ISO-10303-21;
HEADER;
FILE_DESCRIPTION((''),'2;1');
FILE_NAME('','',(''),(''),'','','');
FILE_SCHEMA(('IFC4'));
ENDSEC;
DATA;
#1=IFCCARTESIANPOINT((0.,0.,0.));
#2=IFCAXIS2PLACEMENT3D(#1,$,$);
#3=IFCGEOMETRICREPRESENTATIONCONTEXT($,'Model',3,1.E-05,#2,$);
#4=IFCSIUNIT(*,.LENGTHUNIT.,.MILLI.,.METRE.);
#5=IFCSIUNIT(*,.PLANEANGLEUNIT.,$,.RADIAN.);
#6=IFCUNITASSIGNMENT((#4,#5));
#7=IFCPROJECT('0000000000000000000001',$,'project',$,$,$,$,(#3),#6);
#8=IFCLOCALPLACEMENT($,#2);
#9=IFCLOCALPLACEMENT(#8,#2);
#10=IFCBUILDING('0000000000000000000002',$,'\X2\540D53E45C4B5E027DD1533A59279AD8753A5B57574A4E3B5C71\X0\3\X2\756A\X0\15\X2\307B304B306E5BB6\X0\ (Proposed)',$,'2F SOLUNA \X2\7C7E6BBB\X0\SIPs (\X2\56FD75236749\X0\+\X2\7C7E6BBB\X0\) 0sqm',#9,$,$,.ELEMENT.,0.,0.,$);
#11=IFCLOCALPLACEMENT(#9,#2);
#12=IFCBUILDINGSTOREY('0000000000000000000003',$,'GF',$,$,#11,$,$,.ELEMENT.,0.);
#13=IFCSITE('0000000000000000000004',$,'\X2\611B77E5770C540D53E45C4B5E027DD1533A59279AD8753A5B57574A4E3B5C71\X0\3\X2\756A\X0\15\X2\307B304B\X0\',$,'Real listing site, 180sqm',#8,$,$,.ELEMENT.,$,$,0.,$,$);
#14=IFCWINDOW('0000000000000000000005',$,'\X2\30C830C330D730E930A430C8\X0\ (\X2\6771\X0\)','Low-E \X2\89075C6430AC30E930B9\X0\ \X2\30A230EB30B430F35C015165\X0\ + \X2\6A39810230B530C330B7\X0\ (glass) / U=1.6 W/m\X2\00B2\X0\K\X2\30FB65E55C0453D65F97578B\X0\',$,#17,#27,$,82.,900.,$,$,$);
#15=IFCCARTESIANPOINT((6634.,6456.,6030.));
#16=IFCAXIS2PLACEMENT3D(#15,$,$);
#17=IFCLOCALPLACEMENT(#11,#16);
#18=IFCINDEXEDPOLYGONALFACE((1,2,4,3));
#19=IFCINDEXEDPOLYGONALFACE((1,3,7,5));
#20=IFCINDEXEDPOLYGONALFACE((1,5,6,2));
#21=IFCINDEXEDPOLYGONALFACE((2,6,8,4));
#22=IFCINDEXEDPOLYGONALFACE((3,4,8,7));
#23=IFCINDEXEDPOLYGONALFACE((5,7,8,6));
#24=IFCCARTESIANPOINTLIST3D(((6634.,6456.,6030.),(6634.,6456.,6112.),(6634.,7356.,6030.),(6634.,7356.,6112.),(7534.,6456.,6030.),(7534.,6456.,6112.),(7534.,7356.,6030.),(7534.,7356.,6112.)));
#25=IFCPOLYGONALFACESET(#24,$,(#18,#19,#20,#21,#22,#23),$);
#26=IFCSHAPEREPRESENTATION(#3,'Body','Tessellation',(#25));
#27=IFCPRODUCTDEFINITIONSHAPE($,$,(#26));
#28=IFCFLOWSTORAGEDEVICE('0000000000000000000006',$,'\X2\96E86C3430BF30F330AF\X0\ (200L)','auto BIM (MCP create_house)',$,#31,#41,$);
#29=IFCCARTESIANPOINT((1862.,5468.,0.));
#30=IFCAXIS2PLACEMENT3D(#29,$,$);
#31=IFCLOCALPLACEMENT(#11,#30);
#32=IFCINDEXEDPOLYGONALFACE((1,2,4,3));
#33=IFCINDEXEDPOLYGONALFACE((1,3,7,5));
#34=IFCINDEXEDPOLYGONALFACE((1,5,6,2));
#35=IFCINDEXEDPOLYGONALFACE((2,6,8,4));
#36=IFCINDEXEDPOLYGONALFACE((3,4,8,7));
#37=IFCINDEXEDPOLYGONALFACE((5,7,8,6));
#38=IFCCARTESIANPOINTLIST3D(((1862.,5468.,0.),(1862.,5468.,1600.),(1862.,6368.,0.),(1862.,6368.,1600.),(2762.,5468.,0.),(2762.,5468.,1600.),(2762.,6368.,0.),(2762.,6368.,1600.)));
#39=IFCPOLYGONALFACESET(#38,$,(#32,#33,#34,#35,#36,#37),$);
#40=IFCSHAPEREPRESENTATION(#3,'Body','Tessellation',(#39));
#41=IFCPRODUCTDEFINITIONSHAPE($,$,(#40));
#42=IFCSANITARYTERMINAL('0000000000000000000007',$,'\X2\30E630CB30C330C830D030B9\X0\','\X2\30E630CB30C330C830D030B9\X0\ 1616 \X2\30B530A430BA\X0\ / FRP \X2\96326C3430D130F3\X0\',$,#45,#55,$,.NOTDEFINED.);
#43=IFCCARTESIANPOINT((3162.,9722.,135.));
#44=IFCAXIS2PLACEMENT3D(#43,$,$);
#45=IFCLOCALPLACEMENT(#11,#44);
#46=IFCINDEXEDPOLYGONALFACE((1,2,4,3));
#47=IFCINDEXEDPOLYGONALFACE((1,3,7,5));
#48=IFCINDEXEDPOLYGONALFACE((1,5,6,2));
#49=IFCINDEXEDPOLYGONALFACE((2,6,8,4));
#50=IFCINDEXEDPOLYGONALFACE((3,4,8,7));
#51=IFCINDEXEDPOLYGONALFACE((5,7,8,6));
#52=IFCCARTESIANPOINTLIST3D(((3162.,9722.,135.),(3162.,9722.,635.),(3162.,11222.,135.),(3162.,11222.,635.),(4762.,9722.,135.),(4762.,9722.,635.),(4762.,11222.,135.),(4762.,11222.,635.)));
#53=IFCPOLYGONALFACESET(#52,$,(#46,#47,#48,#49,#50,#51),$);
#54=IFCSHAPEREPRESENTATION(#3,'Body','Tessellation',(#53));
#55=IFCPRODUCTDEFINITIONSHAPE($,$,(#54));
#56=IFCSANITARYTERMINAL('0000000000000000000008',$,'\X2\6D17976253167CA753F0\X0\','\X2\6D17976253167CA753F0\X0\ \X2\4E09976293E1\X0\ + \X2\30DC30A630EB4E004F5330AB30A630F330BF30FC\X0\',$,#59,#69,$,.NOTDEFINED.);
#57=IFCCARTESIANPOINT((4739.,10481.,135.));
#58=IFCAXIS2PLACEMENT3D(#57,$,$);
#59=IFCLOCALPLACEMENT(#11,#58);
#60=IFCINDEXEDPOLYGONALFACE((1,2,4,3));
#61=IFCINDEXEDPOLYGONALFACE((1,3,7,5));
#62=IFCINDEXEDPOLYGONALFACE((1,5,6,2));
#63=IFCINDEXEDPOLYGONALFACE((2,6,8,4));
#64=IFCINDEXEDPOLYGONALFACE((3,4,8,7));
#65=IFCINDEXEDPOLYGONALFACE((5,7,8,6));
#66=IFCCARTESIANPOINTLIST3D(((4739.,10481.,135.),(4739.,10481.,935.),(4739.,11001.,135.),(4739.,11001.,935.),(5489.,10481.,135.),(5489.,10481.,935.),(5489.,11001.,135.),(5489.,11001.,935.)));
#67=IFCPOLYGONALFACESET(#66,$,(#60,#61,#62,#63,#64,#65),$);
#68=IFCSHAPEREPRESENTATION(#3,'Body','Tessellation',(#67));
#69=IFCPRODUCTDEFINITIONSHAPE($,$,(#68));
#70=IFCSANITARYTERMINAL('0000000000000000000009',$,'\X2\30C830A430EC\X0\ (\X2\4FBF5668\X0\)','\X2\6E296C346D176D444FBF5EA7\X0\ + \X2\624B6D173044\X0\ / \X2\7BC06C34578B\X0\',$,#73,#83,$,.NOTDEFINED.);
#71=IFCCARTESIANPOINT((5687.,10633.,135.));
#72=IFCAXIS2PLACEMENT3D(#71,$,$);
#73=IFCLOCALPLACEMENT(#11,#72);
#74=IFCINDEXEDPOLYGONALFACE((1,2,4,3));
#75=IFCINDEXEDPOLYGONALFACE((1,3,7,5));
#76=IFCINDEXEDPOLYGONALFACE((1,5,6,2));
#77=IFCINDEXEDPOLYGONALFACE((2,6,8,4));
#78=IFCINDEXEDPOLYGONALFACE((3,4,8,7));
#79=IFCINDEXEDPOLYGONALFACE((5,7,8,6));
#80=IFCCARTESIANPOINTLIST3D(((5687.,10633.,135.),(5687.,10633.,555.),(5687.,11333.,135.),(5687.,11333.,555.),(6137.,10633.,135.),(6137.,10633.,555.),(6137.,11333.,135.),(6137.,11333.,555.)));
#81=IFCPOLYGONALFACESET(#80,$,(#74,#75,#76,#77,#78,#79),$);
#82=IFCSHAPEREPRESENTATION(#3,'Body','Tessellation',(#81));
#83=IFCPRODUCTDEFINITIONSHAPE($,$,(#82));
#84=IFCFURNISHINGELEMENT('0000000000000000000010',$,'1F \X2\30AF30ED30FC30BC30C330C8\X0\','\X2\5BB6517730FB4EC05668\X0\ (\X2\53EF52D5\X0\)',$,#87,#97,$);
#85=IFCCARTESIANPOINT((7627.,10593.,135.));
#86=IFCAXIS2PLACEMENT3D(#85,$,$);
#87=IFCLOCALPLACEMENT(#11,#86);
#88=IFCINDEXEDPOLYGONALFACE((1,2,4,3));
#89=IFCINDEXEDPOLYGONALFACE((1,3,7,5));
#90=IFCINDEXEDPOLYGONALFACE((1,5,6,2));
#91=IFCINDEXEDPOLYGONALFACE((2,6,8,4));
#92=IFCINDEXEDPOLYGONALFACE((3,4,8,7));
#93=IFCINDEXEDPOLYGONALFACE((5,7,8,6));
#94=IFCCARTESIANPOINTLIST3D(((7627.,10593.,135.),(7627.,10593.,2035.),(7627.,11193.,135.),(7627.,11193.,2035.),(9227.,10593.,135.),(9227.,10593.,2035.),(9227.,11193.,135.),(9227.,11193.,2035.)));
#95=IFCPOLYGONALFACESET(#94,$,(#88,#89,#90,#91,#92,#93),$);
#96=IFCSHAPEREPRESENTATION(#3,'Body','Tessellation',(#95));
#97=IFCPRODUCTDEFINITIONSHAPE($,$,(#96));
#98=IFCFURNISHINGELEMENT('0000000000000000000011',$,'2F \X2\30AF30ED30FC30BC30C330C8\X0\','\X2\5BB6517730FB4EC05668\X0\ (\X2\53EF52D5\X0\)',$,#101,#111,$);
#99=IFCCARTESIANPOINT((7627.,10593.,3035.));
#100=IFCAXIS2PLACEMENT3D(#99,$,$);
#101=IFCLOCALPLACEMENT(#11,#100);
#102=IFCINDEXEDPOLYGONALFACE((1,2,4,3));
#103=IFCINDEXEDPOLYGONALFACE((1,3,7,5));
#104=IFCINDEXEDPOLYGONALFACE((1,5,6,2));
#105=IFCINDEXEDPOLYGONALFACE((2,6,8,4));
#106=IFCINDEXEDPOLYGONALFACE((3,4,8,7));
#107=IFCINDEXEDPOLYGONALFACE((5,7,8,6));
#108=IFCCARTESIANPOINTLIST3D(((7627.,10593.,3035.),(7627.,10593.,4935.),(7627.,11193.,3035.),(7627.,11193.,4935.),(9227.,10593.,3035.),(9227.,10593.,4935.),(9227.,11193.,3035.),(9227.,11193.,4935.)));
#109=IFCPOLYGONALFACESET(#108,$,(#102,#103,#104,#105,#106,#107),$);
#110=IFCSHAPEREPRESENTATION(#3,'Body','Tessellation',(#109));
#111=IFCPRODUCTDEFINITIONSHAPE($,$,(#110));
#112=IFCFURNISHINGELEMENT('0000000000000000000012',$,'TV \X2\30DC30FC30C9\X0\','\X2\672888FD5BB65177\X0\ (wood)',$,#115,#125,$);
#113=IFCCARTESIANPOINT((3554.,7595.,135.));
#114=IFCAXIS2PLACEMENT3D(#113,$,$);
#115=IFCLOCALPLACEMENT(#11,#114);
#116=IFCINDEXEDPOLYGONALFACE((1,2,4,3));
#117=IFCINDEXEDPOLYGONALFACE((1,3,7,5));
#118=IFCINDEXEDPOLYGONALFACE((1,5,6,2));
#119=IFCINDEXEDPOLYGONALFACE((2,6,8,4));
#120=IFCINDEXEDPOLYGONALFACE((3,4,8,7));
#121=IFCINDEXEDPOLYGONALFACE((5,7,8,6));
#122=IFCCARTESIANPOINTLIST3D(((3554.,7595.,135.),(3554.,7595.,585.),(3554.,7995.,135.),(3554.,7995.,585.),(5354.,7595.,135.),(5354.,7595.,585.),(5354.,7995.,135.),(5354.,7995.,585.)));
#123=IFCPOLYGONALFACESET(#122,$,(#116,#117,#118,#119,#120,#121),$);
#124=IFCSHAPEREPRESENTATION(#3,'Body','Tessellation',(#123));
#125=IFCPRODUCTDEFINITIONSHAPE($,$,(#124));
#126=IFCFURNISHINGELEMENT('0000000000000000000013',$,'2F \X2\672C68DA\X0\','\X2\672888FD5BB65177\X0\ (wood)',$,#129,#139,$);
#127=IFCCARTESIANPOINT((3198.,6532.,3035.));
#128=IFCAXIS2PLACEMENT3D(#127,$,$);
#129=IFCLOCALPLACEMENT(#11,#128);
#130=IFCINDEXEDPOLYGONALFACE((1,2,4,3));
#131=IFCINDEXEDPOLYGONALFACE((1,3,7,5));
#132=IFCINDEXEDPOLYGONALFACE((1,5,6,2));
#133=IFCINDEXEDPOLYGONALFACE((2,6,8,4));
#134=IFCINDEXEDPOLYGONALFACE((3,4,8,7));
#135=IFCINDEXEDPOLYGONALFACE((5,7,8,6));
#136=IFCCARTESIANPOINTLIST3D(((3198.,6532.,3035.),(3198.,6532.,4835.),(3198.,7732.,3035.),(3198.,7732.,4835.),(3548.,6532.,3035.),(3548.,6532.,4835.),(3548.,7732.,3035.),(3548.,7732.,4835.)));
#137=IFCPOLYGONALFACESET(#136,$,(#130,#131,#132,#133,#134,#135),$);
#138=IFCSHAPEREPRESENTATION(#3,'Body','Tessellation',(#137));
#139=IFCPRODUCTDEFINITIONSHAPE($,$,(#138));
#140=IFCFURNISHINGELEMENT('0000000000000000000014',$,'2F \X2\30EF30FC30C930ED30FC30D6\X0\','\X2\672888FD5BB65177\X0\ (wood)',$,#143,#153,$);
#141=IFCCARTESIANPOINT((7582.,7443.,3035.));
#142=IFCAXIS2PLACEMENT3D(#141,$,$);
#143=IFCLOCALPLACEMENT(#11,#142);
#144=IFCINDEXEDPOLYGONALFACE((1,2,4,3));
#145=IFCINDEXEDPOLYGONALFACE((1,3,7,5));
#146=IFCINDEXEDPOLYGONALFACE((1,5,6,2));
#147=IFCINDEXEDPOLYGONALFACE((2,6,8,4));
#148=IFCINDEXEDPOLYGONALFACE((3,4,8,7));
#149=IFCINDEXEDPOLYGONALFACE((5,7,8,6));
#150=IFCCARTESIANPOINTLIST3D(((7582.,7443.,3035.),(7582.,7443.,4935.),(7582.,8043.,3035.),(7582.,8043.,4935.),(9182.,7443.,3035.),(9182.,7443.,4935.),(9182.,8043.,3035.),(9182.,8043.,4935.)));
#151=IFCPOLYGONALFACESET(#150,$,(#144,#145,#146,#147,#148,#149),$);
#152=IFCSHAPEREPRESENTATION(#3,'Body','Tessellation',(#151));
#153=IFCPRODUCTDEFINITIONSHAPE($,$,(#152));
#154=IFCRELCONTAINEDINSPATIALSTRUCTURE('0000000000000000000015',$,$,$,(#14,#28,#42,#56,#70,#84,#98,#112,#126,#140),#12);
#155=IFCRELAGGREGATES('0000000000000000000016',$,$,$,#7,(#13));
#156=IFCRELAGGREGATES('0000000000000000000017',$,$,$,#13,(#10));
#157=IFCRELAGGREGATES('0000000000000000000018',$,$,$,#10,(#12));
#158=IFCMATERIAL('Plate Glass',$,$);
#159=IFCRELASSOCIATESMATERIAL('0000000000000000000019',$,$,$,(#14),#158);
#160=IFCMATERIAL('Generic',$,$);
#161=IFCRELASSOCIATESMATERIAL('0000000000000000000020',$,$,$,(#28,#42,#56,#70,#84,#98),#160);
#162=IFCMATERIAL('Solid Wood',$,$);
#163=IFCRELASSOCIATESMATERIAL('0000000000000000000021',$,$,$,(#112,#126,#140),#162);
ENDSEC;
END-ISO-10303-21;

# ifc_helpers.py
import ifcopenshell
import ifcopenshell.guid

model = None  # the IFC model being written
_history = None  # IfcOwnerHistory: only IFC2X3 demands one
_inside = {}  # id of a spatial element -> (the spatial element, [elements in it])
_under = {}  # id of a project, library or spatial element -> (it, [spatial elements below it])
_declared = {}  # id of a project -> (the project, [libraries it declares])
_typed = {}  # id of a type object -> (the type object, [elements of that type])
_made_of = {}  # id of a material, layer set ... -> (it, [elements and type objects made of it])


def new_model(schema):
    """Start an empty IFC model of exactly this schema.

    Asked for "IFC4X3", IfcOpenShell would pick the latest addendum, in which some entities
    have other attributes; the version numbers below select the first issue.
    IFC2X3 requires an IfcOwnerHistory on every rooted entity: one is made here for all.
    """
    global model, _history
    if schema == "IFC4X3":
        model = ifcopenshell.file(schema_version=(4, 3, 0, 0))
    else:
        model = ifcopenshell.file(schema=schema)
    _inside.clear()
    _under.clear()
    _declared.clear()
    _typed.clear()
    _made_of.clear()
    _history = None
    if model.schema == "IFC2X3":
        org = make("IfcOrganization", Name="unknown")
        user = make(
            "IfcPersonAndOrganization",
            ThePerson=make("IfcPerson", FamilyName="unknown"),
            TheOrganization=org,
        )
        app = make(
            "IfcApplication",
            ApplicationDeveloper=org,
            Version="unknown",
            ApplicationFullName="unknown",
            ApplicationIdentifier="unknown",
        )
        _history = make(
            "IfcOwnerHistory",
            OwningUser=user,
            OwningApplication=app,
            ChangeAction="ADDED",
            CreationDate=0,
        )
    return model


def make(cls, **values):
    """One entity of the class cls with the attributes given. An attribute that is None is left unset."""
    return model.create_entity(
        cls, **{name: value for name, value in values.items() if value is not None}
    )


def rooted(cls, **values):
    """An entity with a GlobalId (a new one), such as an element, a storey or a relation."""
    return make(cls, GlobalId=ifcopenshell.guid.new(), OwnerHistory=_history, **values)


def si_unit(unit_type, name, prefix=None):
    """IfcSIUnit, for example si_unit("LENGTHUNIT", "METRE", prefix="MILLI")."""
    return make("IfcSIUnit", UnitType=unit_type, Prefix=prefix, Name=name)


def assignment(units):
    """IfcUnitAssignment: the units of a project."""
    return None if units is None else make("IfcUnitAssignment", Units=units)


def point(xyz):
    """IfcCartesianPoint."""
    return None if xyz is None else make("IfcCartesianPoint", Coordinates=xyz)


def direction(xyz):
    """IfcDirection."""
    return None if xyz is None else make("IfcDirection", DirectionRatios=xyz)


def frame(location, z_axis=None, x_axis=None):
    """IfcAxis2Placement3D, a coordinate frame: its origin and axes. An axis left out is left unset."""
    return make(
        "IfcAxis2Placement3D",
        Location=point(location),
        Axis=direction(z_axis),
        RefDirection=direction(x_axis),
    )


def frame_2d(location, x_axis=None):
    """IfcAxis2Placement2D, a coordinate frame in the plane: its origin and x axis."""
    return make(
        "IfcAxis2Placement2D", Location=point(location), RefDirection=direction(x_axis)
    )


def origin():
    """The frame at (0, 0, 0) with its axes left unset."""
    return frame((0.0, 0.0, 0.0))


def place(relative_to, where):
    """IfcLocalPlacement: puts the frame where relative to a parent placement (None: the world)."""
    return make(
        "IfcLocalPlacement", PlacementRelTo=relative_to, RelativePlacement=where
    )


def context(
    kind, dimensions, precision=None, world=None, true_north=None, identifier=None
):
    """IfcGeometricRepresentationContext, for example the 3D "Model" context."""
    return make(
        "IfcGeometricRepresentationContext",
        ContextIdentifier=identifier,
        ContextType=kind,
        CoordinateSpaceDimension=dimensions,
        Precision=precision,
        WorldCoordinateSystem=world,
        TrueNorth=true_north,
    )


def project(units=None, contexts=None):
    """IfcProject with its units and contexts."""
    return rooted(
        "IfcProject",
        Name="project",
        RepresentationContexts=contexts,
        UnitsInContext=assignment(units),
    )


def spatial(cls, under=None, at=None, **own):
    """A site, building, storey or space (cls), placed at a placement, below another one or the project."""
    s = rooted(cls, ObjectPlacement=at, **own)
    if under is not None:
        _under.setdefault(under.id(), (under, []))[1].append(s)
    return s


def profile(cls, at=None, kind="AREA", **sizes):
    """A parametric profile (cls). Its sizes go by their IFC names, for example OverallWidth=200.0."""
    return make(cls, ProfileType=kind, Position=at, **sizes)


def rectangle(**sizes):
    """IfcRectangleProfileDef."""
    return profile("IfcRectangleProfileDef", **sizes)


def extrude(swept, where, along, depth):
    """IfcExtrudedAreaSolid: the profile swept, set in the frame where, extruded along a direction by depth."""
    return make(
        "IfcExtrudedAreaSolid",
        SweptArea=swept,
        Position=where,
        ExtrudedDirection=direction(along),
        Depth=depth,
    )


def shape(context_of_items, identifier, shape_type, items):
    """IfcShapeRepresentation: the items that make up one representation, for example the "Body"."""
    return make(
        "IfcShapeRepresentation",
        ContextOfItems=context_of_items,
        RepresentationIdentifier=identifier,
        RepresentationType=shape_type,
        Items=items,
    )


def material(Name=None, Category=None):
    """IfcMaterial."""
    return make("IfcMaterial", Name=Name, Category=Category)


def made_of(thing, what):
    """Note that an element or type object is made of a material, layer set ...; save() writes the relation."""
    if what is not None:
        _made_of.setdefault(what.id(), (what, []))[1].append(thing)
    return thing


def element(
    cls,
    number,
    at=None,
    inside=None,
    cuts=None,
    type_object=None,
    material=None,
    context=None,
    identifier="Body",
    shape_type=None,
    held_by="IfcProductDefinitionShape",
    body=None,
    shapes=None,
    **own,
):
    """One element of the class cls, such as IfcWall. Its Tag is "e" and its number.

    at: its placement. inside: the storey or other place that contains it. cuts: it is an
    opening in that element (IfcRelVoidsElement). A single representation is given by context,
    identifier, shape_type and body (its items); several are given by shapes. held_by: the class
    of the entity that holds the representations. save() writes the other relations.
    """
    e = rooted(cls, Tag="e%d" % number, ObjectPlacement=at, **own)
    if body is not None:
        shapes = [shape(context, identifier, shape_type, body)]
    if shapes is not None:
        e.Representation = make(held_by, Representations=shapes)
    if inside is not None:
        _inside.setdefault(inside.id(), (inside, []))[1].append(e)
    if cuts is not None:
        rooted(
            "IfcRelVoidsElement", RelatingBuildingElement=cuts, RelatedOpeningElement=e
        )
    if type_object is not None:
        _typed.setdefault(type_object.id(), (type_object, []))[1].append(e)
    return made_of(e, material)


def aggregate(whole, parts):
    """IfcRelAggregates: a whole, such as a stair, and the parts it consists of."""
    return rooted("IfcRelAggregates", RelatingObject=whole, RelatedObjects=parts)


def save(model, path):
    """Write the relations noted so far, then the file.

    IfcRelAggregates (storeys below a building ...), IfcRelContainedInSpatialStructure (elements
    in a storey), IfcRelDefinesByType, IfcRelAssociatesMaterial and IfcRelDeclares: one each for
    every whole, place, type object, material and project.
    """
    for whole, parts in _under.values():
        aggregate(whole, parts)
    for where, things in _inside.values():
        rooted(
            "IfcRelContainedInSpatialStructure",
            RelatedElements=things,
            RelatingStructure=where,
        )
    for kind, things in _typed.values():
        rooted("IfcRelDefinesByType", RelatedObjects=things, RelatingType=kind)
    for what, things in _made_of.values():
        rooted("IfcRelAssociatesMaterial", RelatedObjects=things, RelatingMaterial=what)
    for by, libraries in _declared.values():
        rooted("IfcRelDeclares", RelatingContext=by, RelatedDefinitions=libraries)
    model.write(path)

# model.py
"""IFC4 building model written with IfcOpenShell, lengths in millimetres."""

from ifc_helpers import new_model, si_unit, frame, frame_2d, origin, place, context, project, spatial, rectangle, extrude, material, element, save


model = new_model("IFC4")

# Units and contexts
model_context = context("Model", 3, precision=1e-05, world=origin())
ifc_project = project(units=[si_unit("LENGTHUNIT", "METRE", prefix="MILLI"), si_unit("PLANEANGLEUNIT", "RADIAN")], contexts=[model_context])

# Site, building, storey
site_placement = place(None, origin())
site = spatial("IfcSite", under=ifc_project, at=site_placement, Name="愛知県名古屋市緑区大高町字坊主山3番15ほか", ObjectType="Real listing site, 180sqm", CompositionType="ELEMENT", RefElevation=0.0)
building_placement = place(site_placement, origin())
building = spatial("IfcBuilding", under=site, at=building_placement, Name="名古屋市緑区大高町字坊主山3番15ほかの家 (Proposed)", ObjectType="2F SOLUNA 籾殻SIPs (国産杉+籾殻) 0sqm", CompositionType="ELEMENT", ElevationOfRefHeight=0.0, ElevationOfTerrain=0.0)
storey_placement = place(building_placement, origin())
storey = spatial("IfcBuildingStorey", under=building, at=storey_placement, Name="GF", CompositionType="ELEMENT", Elevation=0.0)

# Shared definitions
ifc_material_1 = material(Name="Solid Wood")
ifc_material_2 = material(Name="Plate Glass")

# Window
window_1_placement = place(storey_placement, frame((6634.0, 6456.0, 6030.0)))
element("IfcWindow", 1, at=window_1_placement, inside=storey, material=ifc_material_2, Name="トップライト (東)", Description="Low-E 複層ガラス アルゴン封入 + 樹脂サッシ (glass) / U=1.6 W/m²K・日射取得型", OverallHeight=82.0, OverallWidth=900.0, context=model_context, shape_type="SweptSolid", body=[
    extrude(rectangle(XDim=900.0, YDim=900.0, at=frame_2d((450.0, 450.0))), frame((6634.0, 6456.0, 6030.0)), (0.0, 0.0, 1.0), 82.0),
])

# Flow storage device
ifc_material_3 = material(Name="Generic")
flow_storage_device_placement = place(storey_placement, frame((1862.0, 5468.0, 0.0)))
element("IfcFlowStorageDevice", 2, at=flow_storage_device_placement, inside=storey, material=ifc_material_3, Name="雨水タンク (200L)", Description="auto BIM (MCP create_house)", context=model_context, shape_type="SweptSolid", body=[
    extrude(rectangle(XDim=900.0, YDim=900.0, at=frame_2d((450.0, 450.0))), frame((1862.0, 5468.0, 0.0)), (0.0, 0.0, 1.0), 1600.0),
])

# Sanitary terminals
sanitary_terminal_1_placement = place(storey_placement, frame((3162.0, 9722.0, 135.0)))
element("IfcSanitaryTerminal", 3, at=sanitary_terminal_1_placement, inside=storey, material=ifc_material_3, Name="ユニットバス", Description="ユニットバス 1616 サイズ / FRP 防水パン", PredefinedType="NOTDEFINED", context=model_context, shape_type="SweptSolid", body=[
    extrude(rectangle(XDim=1600.0, YDim=1500.0, at=frame_2d((800.0, 750.0))), frame((3162.0, 9722.0, 135.0)), (0.0, 0.0, 1.0), 500.0),
])
sanitary_terminal_2_placement = place(storey_placement, frame((4739.0, 10481.0, 135.0)))
element("IfcSanitaryTerminal", 4, at=sanitary_terminal_2_placement, inside=storey, material=ifc_material_3, Name="洗面化粧台", Description="洗面化粧台 三面鏡 + ボウル一体カウンター", PredefinedType="NOTDEFINED", context=model_context, shape_type="SweptSolid", body=[
    extrude(rectangle(XDim=750.0, YDim=520.0, at=frame_2d((375.0, 260.0))), frame((4739.0, 10481.0, 135.0)), (0.0, 0.0, 1.0), 800.0),
])
sanitary_terminal_3_placement = place(storey_placement, frame((5687.0, 10633.0, 135.0)))
element("IfcSanitaryTerminal", 5, at=sanitary_terminal_3_placement, inside=storey, material=ifc_material_3, Name="トイレ (便器)", Description="温水洗浄便座 + 手洗い / 節水型", PredefinedType="NOTDEFINED", context=model_context, shape_type="SweptSolid", body=[
    extrude(rectangle(XDim=450.0, YDim=700.0, at=frame_2d((225.0, 350.0))), frame((5687.0, 10633.0, 135.0)), (0.0, 0.0, 1.0), 420.0),
])

# Furnishing elements
furnishing_1_placement = place(storey_placement, frame((7627.0, 10593.0, 135.0)))
element("IfcFurnishingElement", 6, at=furnishing_1_placement, inside=storey, material=ifc_material_3, Name="1F クローゼット", Description="家具・什器 (可動)", context=model_context, shape_type="SweptSolid", body=[
    extrude(rectangle(XDim=1600.0, YDim=600.0, at=frame_2d((800.0, 300.0))), frame((7627.0, 10593.0, 135.0)), (0.0, 0.0, 1.0), 1900.0),
])
furnishing_2_placement = place(storey_placement, frame((7627.0, 10593.0, 3035.0)))
element("IfcFurnishingElement", 7, at=furnishing_2_placement, inside=storey, material=ifc_material_3, Name="2F クローゼット", Description="家具・什器 (可動)", context=model_context, shape_type="SweptSolid", body=[
    extrude(rectangle(XDim=1600.0, YDim=600.0, at=frame_2d((800.0, 300.0))), frame((7627.0, 10593.0, 3035.0)), (0.0, 0.0, 1.0), 1900.0),
])
furnishing_3_placement = place(storey_placement, frame((3554.0, 7595.0, 135.0)))
element("IfcFurnishingElement", 8, at=furnishing_3_placement, inside=storey, material=ifc_material_1, Name="TV ボード", Description="木製家具 (wood)", context=model_context, shape_type="SweptSolid", body=[
    extrude(rectangle(XDim=1800.0, YDim=400.0, at=frame_2d((900.0, 200.0))), frame((3554.0, 7595.0, 135.0)), (0.0, 0.0, 1.0), 450.0),
])
furnishing_4_placement = place(storey_placement, frame((3198.0, 6532.0, 3035.0)))
element("IfcFurnishingElement", 9, at=furnishing_4_placement, inside=storey, material=ifc_material_1, Name="2F 本棚", Description="木製家具 (wood)", context=model_context, shape_type="SweptSolid", body=[
    extrude(rectangle(XDim=350.0, YDim=1200.0, at=frame_2d((175.0, 600.0))), frame((3198.0, 6532.0, 3035.0)), (0.0, 0.0, 1.0), 1800.0),
])
furnishing_5_placement = place(storey_placement, frame((7582.0, 7443.0, 3035.0)))
element("IfcFurnishingElement", 10, at=furnishing_5_placement, inside=storey, material=ifc_material_1, Name="2F ワードローブ", Description="木製家具 (wood)", context=model_context, shape_type="SweptSolid", body=[
    extrude(rectangle(XDim=1600.0, YDim=600.0, at=frame_2d((800.0, 300.0))), frame((7582.0, 7443.0, 3035.0)), (0.0, 0.0, 1.0), 1900.0),
])

save(model, "model.ifc")
